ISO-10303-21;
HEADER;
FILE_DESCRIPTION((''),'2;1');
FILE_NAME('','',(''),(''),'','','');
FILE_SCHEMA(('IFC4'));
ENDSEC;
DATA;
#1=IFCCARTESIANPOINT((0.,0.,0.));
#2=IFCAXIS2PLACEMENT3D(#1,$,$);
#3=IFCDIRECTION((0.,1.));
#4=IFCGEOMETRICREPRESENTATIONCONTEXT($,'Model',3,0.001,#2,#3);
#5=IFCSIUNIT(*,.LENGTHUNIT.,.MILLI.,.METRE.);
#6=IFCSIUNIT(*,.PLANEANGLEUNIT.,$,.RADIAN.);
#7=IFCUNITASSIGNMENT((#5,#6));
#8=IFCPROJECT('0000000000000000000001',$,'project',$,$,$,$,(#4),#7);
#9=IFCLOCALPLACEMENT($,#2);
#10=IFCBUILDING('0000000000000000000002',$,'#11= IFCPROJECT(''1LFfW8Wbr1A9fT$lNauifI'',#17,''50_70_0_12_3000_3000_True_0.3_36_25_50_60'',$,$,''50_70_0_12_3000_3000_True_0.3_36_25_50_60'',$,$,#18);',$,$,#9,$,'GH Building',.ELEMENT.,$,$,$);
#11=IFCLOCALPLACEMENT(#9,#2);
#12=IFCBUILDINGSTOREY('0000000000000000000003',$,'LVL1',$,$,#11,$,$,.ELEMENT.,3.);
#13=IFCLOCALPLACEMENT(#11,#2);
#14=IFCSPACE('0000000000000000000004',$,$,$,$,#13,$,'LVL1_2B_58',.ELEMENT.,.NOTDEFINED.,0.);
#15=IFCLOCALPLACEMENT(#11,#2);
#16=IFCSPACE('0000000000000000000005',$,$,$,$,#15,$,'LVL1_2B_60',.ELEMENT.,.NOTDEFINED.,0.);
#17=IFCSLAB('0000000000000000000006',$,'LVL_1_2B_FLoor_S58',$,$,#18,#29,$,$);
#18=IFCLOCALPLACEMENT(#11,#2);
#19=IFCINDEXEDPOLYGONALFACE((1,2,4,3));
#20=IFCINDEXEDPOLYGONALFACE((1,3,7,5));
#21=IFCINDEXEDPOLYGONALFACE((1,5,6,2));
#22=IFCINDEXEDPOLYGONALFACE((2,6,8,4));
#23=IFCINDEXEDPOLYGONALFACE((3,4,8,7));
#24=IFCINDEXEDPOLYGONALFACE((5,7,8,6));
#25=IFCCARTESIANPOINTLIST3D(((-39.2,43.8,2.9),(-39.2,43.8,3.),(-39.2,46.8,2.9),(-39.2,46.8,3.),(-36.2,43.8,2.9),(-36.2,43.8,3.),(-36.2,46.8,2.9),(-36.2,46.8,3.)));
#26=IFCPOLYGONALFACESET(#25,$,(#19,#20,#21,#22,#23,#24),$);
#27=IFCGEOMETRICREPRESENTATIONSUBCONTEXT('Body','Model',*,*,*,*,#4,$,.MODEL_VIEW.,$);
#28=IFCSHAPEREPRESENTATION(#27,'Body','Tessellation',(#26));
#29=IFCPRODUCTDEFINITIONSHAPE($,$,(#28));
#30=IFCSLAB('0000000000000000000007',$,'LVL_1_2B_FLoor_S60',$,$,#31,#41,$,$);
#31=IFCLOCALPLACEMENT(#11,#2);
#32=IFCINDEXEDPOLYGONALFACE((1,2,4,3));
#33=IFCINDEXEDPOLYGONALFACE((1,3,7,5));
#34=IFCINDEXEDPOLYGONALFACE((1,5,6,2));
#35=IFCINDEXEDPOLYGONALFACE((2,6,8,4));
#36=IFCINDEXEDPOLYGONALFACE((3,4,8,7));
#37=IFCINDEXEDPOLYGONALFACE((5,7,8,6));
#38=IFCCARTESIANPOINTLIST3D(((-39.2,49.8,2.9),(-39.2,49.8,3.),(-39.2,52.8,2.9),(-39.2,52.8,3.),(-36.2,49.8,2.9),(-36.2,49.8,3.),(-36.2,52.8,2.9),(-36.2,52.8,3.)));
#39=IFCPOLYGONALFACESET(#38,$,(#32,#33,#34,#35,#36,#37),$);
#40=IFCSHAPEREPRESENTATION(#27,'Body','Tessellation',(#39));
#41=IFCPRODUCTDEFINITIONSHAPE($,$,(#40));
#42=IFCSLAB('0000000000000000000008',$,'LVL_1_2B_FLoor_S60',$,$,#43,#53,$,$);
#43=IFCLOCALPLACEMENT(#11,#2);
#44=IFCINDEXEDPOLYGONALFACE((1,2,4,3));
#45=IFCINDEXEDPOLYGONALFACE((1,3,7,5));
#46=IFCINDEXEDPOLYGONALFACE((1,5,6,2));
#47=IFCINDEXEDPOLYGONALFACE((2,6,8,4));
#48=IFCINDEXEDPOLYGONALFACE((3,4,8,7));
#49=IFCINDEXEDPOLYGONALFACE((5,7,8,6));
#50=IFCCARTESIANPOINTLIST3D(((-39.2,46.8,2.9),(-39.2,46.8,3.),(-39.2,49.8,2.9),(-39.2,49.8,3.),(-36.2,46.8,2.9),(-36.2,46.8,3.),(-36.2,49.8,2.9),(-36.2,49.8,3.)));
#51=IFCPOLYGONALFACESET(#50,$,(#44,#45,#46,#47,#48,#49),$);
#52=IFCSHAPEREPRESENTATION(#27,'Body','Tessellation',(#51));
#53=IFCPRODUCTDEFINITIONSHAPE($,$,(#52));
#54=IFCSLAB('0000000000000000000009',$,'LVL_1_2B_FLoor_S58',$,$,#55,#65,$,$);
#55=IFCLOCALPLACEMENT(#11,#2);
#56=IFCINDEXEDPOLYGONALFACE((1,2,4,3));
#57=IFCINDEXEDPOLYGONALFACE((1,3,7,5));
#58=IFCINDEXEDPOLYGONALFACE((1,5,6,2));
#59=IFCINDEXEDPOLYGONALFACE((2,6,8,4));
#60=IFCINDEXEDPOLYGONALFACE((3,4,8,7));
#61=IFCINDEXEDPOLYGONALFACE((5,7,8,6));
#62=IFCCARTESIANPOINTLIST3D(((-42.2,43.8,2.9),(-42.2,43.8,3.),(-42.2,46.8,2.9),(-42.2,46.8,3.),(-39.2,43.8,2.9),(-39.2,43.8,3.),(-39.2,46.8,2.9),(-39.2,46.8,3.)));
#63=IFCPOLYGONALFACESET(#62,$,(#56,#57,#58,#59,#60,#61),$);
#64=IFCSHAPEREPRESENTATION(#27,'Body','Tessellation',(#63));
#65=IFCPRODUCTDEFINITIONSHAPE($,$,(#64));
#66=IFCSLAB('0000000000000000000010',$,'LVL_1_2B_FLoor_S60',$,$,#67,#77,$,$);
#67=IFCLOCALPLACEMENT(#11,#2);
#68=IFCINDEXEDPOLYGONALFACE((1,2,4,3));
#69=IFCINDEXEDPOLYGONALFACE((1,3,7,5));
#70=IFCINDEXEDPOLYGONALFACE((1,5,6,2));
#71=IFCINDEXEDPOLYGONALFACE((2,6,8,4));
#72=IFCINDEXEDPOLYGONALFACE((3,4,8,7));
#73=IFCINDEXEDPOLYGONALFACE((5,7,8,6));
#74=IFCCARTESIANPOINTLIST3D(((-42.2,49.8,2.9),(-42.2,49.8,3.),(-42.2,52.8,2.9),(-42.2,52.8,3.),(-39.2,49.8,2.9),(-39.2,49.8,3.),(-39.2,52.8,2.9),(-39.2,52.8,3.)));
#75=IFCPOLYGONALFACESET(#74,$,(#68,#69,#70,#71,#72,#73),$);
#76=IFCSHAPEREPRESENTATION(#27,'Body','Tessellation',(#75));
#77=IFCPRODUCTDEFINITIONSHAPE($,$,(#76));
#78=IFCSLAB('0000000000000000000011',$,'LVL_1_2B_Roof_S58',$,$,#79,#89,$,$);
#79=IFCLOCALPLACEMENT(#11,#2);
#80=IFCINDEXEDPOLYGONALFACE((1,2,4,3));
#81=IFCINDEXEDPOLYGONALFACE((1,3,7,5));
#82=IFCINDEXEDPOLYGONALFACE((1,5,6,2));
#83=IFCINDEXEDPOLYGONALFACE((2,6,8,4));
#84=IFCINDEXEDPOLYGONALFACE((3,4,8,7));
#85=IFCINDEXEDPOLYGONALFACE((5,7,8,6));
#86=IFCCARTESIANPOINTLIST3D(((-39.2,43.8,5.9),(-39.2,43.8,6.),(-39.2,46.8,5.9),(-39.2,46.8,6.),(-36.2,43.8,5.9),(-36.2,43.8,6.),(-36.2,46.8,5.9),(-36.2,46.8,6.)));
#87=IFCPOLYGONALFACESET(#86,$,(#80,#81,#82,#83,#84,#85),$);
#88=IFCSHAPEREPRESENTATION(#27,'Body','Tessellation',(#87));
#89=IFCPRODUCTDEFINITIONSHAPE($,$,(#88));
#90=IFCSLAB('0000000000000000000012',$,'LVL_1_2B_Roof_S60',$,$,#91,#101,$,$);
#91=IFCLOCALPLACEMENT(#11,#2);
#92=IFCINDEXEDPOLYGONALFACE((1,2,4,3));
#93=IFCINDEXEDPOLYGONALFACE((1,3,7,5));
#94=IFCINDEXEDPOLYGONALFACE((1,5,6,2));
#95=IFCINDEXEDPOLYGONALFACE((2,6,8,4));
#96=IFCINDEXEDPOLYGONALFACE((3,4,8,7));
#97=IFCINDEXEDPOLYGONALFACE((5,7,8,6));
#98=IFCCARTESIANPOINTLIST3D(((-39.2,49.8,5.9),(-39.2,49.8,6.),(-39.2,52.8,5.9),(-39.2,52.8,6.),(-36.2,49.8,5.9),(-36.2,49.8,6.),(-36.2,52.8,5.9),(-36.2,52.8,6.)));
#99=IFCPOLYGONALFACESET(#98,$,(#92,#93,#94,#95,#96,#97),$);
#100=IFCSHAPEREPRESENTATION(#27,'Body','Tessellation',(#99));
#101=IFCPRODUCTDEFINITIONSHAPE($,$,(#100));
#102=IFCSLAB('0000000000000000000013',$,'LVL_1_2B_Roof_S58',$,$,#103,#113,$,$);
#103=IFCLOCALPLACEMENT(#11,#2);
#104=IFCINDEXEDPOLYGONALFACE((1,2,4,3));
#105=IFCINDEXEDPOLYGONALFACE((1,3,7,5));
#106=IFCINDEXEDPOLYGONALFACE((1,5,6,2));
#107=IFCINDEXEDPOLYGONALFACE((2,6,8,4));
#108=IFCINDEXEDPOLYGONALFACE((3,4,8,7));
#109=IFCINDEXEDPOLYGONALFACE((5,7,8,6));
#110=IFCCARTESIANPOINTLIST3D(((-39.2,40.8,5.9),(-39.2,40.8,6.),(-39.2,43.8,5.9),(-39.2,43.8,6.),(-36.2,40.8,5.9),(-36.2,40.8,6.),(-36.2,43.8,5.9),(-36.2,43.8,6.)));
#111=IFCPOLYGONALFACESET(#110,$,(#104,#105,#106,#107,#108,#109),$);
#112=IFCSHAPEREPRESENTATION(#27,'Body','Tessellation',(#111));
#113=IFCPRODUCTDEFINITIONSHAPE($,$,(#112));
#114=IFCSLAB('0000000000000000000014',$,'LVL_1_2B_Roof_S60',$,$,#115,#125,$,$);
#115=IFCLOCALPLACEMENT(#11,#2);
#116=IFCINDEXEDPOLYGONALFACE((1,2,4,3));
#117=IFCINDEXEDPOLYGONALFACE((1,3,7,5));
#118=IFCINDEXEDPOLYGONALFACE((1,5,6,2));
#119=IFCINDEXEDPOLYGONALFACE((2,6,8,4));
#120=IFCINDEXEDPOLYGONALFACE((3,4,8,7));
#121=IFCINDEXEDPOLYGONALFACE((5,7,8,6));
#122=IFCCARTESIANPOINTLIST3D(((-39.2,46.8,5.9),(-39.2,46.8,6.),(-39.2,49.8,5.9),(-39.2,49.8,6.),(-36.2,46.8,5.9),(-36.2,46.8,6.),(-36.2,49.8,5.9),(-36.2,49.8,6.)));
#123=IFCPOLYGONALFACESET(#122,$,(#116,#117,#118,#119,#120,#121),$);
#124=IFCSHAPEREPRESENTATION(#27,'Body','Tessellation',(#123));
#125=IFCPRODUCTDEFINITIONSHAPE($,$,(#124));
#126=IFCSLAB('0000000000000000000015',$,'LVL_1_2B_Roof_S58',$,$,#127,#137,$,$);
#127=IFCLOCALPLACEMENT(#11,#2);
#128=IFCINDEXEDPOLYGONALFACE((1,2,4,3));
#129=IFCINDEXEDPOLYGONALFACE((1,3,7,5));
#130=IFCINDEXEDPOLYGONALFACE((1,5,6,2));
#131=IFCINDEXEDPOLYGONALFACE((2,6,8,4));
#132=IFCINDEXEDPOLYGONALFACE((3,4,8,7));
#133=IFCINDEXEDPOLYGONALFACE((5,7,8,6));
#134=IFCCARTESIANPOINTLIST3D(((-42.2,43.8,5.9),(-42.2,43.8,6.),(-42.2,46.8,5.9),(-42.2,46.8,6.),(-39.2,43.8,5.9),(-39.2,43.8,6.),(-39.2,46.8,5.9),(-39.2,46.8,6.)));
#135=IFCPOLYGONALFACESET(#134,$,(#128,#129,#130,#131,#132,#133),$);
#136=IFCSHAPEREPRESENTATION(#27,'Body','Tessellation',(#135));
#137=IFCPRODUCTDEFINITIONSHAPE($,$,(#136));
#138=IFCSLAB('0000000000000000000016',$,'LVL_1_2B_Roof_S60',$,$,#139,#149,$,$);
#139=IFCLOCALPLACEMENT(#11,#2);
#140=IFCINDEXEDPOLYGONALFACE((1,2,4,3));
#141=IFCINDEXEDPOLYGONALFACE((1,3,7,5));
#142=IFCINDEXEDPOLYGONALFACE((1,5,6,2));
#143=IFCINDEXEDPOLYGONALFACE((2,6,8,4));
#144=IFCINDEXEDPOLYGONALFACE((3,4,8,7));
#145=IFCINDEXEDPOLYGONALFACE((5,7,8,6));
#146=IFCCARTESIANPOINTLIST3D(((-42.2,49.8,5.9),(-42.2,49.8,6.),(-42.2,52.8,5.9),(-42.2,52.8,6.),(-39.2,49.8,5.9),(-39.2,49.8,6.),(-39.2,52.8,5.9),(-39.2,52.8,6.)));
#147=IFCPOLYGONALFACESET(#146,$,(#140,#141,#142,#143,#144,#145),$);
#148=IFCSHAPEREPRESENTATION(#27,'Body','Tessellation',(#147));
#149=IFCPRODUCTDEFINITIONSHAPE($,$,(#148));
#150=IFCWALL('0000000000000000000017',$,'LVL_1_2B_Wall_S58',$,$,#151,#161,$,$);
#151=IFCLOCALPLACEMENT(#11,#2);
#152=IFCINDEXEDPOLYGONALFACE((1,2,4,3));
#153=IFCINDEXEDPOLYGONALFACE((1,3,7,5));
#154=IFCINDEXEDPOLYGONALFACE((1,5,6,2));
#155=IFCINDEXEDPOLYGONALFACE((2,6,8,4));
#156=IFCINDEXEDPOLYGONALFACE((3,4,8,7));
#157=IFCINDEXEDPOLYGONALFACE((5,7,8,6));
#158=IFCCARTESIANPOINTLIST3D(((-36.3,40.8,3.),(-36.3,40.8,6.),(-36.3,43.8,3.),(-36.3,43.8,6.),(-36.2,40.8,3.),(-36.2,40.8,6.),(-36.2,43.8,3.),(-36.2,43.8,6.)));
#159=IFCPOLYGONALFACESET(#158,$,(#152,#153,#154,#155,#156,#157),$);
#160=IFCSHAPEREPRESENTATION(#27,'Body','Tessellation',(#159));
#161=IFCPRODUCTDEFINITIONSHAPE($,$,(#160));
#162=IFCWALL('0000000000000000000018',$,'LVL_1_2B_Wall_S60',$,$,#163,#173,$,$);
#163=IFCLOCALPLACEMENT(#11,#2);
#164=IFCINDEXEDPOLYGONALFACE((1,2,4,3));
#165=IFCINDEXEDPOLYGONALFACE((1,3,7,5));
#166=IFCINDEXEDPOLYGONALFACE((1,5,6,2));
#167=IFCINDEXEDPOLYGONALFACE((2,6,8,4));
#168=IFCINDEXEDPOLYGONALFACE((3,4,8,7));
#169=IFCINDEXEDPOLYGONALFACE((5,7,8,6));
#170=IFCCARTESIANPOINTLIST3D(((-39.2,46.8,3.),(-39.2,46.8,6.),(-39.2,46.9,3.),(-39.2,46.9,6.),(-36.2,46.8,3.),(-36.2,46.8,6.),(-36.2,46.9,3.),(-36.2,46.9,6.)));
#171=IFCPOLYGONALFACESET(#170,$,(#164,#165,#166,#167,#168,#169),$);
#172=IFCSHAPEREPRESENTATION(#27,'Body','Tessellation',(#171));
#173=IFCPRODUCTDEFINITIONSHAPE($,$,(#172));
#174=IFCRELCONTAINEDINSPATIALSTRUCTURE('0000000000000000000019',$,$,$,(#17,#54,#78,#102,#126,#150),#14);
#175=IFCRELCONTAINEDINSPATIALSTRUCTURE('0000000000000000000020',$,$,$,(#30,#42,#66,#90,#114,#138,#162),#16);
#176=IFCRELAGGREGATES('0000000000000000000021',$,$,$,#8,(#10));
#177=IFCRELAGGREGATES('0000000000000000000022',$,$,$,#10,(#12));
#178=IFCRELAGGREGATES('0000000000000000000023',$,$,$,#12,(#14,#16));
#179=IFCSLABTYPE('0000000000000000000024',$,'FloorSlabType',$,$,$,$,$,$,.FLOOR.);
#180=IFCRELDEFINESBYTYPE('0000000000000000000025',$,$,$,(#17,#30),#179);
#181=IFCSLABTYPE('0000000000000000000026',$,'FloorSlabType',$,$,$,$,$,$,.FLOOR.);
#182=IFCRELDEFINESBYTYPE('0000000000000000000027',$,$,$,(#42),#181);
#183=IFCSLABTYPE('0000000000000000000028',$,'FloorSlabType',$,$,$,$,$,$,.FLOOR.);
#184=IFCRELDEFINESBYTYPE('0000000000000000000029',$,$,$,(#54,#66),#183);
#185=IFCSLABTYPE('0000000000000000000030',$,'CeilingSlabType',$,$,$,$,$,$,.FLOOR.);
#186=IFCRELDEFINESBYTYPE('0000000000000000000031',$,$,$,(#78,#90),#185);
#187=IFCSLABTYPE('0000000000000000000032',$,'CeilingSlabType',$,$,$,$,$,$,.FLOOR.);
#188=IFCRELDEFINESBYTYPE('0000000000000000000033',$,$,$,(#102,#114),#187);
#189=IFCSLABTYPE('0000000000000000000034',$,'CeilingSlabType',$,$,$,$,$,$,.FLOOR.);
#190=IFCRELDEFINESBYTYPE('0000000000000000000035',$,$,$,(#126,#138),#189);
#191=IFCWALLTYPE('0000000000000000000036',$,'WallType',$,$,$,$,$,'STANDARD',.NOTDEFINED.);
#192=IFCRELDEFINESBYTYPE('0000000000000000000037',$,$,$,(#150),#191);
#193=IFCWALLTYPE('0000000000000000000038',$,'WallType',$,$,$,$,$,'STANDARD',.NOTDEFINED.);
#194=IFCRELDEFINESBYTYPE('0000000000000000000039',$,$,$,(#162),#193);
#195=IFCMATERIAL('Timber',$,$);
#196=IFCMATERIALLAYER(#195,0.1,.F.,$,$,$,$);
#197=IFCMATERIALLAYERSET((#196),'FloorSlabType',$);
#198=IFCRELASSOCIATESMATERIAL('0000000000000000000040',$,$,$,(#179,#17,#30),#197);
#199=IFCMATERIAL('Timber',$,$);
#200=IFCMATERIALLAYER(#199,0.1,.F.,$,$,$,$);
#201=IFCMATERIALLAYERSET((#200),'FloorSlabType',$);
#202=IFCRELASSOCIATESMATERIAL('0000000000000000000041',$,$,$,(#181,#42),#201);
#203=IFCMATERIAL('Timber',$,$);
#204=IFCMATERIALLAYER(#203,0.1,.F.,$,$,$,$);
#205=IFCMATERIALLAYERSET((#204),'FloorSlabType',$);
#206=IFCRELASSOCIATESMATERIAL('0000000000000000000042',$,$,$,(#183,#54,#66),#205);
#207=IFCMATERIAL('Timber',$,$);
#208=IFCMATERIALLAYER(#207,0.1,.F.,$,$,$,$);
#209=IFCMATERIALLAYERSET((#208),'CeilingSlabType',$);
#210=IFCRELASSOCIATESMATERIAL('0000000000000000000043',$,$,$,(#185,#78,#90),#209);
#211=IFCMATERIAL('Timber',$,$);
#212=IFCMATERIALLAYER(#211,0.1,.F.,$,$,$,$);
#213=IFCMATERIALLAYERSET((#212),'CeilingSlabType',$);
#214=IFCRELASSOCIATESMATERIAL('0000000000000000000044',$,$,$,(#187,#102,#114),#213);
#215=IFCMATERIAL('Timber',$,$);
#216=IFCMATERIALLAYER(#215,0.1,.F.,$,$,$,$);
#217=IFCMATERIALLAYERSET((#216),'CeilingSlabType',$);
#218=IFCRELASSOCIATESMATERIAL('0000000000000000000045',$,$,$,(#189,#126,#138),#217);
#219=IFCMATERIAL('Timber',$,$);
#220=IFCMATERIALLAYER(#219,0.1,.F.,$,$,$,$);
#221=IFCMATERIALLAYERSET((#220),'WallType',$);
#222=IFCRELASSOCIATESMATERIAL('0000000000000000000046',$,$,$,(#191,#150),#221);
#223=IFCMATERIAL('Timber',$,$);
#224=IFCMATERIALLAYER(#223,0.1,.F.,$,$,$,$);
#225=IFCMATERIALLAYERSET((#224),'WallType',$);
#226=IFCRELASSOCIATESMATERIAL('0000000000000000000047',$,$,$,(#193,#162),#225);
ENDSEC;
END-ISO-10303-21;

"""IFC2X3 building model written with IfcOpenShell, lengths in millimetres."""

from ifc_helpers import new_model, si_unit, direction, frame, frame_2d, origin, place, context, subcontext, project, spatial, rectangle, extrude, material, layer, layer_set, layer_usage, type_object, element, save


model = new_model("IFC2X3")

# Units and contexts
model_context = context("Model", 3, precision=0.001, world=origin(), true_north=direction((0.0, 1.0)))
body_context = subcontext(model_context, "Body", "Model", "MODEL_VIEW")
ifc_project = project(units=[si_unit("LENGTHUNIT", "METRE", prefix="MILLI"), si_unit("PLANEANGLEUNIT", "RADIAN")], contexts=[model_context])

# Building, storey
building_placement = place(None, origin())
building = spatial("IfcBuilding", under=ifc_project, at=building_placement, Name="#11= IFCPROJECT('1LFfW8Wbr1A9fT$lNauifI',#17,'50_70_0_12_3000_3000_True_0.3_36_25_50_60',$,$,'50_70_0_12_3000_3000_True_0.3_36_25_50_60',$,$,#18);", LongName="GH Building", CompositionType="ELEMENT")
storey_placement = place(building_placement, origin())
storey = spatial("IfcBuildingStorey", under=building, at=storey_placement, Name="LVL1", CompositionType="ELEMENT", Elevation=3.0)

# Shared definitions
space_1_placement = place(storey_placement, origin())
space_1 = spatial("IfcSpace", under=storey, at=space_1_placement, LongName="LVL1_2B_58", CompositionType="ELEMENT", InteriorOrExteriorSpace="NOTDEFINED", ElevationWithFlooring=0.0)

# Slab
ifc_material_1 = material(Name="Timber")
ifc_layer_1 = layer(ifc_material_1, 0.1, ventilated=False)
ifc_layer_set_1 = layer_set([ifc_layer_1], Name="FloorSlabType")
ifc_layer_usage_1 = layer_usage(ifc_layer_set_1, "AXIS3", "NEGATIVE", -0.1)
slab_type_1 = type_object("IfcSlabType", Name="FloorSlabType", PredefinedType="FLOOR", material=ifc_layer_set_1)
slab_1_placement = place(space_1_placement, frame((-39.2, 46.8, 2.9), z_axis=(0.0, 0.0, 1.0), x_axis=(0.0, -1.0, 0.0)))
element("IfcSlab", 1, at=slab_1_placement, inside=space_1, type_object=slab_type_1, material=ifc_layer_usage_1, Name="LVL_1_2B_FLoor_S58", context=body_context, shape_type="SweptSolid", body=[
    extrude(rectangle(XDim=3.0, YDim=3.0, at=frame_2d((1.5, 1.5))), origin(), (0.0, 0.0, 1.0), 0.1),
])

# Shared definitions
space_2_placement = place(storey_placement, origin())
space_2 = spatial("IfcSpace", under=storey, at=space_2_placement, LongName="LVL1_2B_60", CompositionType="ELEMENT", InteriorOrExteriorSpace="NOTDEFINED", ElevationWithFlooring=0.0)

# Slabs
ifc_layer_usage_2 = layer_usage(ifc_layer_set_1, "AXIS3", "NEGATIVE", -0.1)
slab_2_placement = place(space_2_placement, frame((-39.2, 52.8, 2.9), z_axis=(0.0, 0.0, 1.0), x_axis=(0.0, -1.0, 0.0)))
element("IfcSlab", 2, at=slab_2_placement, inside=space_2, type_object=slab_type_1, material=ifc_layer_usage_2, Name="LVL_1_2B_FLoor_S60", context=body_context, shape_type="SweptSolid", body=[
    extrude(rectangle(XDim=3.0, YDim=3.0, at=frame_2d((1.5, 1.5))), origin(), (0.0, 0.0, 1.0), 0.1),
])
ifc_material_2 = material(Name="Timber")
ifc_layer_2 = layer(ifc_material_2, 0.1, ventilated=False)
ifc_layer_set_2 = layer_set([ifc_layer_2], Name="FloorSlabType")
ifc_layer_usage_3 = layer_usage(ifc_layer_set_2, "AXIS3", "NEGATIVE", -0.1)
slab_type_2 = type_object("IfcSlabType", Name="FloorSlabType", PredefinedType="FLOOR", material=ifc_layer_set_2)
slab_3_placement = place(space_2_placement, frame((-39.2, 49.8, 2.9), z_axis=(0.0, 0.0, 1.0), x_axis=(0.0, -1.0, 0.0)))
element("IfcSlab", 3, at=slab_3_placement, inside=space_2, type_object=slab_type_2, material=ifc_layer_usage_3, Name="LVL_1_2B_FLoor_S60", context=body_context, shape_type="SweptSolid", body=[
    extrude(rectangle(XDim=3.0, YDim=3.0, at=frame_2d((1.5, 1.5))), origin(), (0.0, 0.0, 1.0), 0.1),
])
ifc_material_3 = material(Name="Timber")
ifc_layer_3 = layer(ifc_material_3, 0.1, ventilated=False)
ifc_layer_set_3 = layer_set([ifc_layer_3], Name="FloorSlabType")
ifc_layer_usage_4 = layer_usage(ifc_layer_set_3, "AXIS3", "NEGATIVE", -0.1)
slab_type_3 = type_object("IfcSlabType", Name="FloorSlabType", PredefinedType="FLOOR", material=ifc_layer_set_3)
slab_4_placement = place(space_1_placement, frame((-42.2, 46.8, 2.9), z_axis=(0.0, 0.0, 1.0), x_axis=(0.0, -1.0, 0.0)))
element("IfcSlab", 4, at=slab_4_placement, inside=space_1, type_object=slab_type_3, material=ifc_layer_usage_4, Name="LVL_1_2B_FLoor_S58", context=body_context, shape_type="SweptSolid", body=[
    extrude(rectangle(XDim=3.0, YDim=3.0, at=frame_2d((1.5, 1.5))), origin(), (0.0, 0.0, 1.0), 0.1),
])
ifc_layer_usage_5 = layer_usage(ifc_layer_set_3, "AXIS3", "NEGATIVE", -0.1)
slab_5_placement = place(space_2_placement, frame((-42.2, 52.8, 2.9), z_axis=(0.0, 0.0, 1.0), x_axis=(0.0, -1.0, 0.0)))
element("IfcSlab", 5, at=slab_5_placement, inside=space_2, type_object=slab_type_3, material=ifc_layer_usage_5, Name="LVL_1_2B_FLoor_S60", context=body_context, shape_type="SweptSolid", body=[
    extrude(rectangle(XDim=3.0, YDim=3.0, at=frame_2d((1.5, 1.5))), origin(), (0.0, 0.0, 1.0), 0.1),
])
ifc_material_4 = material(Name="Timber")
ifc_layer_4 = layer(ifc_material_4, 0.1, ventilated=False)
ifc_layer_set_4 = layer_set([ifc_layer_4], Name="CeilingSlabType")
ifc_layer_usage_6 = layer_usage(ifc_layer_set_4, "AXIS3", "NEGATIVE", -0.1)
slab_type_4 = type_object("IfcSlabType", Name="CeilingSlabType", PredefinedType="FLOOR", material=ifc_layer_set_4)
slab_6_placement = place(space_1_placement, frame((-39.2, 46.8, 5.9), z_axis=(0.0, 0.0, 1.0), x_axis=(0.0, -1.0, 0.0)))
element("IfcSlab", 6, at=slab_6_placement, inside=space_1, type_object=slab_type_4, material=ifc_layer_usage_6, Name="LVL_1_2B_Roof_S58", context=body_context, shape_type="SweptSolid", body=[
    extrude(rectangle(XDim=3.0, YDim=3.0, at=frame_2d((1.5, 1.5))), origin(), (0.0, 0.0, 1.0), 0.1),
])
ifc_layer_usage_7 = layer_usage(ifc_layer_set_4, "AXIS3", "NEGATIVE", -0.1)
slab_7_placement = place(space_2_placement, frame((-39.2, 52.8, 5.9), z_axis=(0.0, 0.0, 1.0), x_axis=(0.0, -1.0, 0.0)))
element("IfcSlab", 7, at=slab_7_placement, inside=space_2, type_object=slab_type_4, material=ifc_layer_usage_7, Name="LVL_1_2B_Roof_S60", context=body_context, shape_type="SweptSolid", body=[
    extrude(rectangle(XDim=3.0, YDim=3.0, at=frame_2d((1.5, 1.5))), origin(), (0.0, 0.0, 1.0), 0.1),
])
ifc_material_5 = material(Name="Timber")
ifc_layer_5 = layer(ifc_material_5, 0.1, ventilated=False)
ifc_layer_set_5 = layer_set([ifc_layer_5], Name="CeilingSlabType")
ifc_layer_usage_8 = layer_usage(ifc_layer_set_5, "AXIS3", "NEGATIVE", -0.1)
slab_type_5 = type_object("IfcSlabType", Name="CeilingSlabType", PredefinedType="FLOOR", material=ifc_layer_set_5)
slab_8_placement = place(space_1_placement, frame((-39.2, 43.8, 5.9), z_axis=(0.0, 0.0, 1.0), x_axis=(0.0, -1.0, 0.0)))
element("IfcSlab", 8, at=slab_8_placement, inside=space_1, type_object=slab_type_5, material=ifc_layer_usage_8, Name="LVL_1_2B_Roof_S58", context=body_context, shape_type="SweptSolid", body=[
    extrude(rectangle(XDim=3.0, YDim=3.0, at=frame_2d((1.5, 1.5))), origin(), (0.0, 0.0, 1.0), 0.1),
])
ifc_layer_usage_9 = layer_usage(ifc_layer_set_5, "AXIS3", "NEGATIVE", -0.1)
slab_9_placement = place(space_2_placement, frame((-39.2, 49.8, 5.9), z_axis=(0.0, 0.0, 1.0), x_axis=(0.0, -1.0, 0.0)))
element("IfcSlab", 9, at=slab_9_placement, inside=space_2, type_object=slab_type_5, material=ifc_layer_usage_9, Name="LVL_1_2B_Roof_S60", context=body_context, shape_type="SweptSolid", body=[
    extrude(rectangle(XDim=3.0, YDim=3.0, at=frame_2d((1.5, 1.5))), origin(), (0.0, 0.0, 1.0), 0.1),
])
ifc_material_6 = material(Name="Timber")
ifc_layer_6 = layer(ifc_material_6, 0.1, ventilated=False)
ifc_layer_set_6 = layer_set([ifc_layer_6], Name="CeilingSlabType")
ifc_layer_usage_10 = layer_usage(ifc_layer_set_6, "AXIS3", "NEGATIVE", -0.1)
slab_type_6 = type_object("IfcSlabType", Name="CeilingSlabType", PredefinedType="FLOOR", material=ifc_layer_set_6)
slab_10_placement = place(space_1_placement, frame((-42.2, 46.8, 5.9), z_axis=(0.0, 0.0, 1.0), x_axis=(0.0, -1.0, 0.0)))
element("IfcSlab", 10, at=slab_10_placement, inside=space_1, type_object=slab_type_6, material=ifc_layer_usage_10, Name="LVL_1_2B_Roof_S58", context=body_context, shape_type="SweptSolid", body=[
    extrude(rectangle(XDim=3.0, YDim=3.0, at=frame_2d((1.5, 1.5))), origin(), (0.0, 0.0, 1.0), 0.1),
])
ifc_layer_usage_11 = layer_usage(ifc_layer_set_6, "AXIS3", "NEGATIVE", -0.1)
slab_11_placement = place(space_2_placement, frame((-42.2, 52.8, 5.9), z_axis=(0.0, 0.0, 1.0), x_axis=(0.0, -1.0, 0.0)))
element("IfcSlab", 11, at=slab_11_placement, inside=space_2, type_object=slab_type_6, material=ifc_layer_usage_11, Name="LVL_1_2B_Roof_S60", context=body_context, shape_type="SweptSolid", body=[
    extrude(rectangle(XDim=3.0, YDim=3.0, at=frame_2d((1.5, 1.5))), origin(), (0.0, 0.0, 1.0), 0.1),
])

# Walls
ifc_material_7 = material(Name="Timber")
ifc_layer_7 = layer(ifc_material_7, 0.1, ventilated=False)
ifc_layer_set_7 = layer_set([ifc_layer_7], Name="WallType")
ifc_layer_usage_12 = layer_usage(ifc_layer_set_7, "AXIS2", "NEGATIVE", 0.0)
wall_type_1 = type_object("IfcWallType", Name="WallType", ElementType="STANDARD", PredefinedType="NOTDEFINED", material=ifc_layer_set_7)
wall_1_placement = place(space_1_placement, frame((-36.2, 43.8, 3.0), z_axis=(0.0, 0.0, 1.0), x_axis=(0.0, -1.0, 0.0)))
element("IfcWall", 12, at=wall_1_placement, inside=space_1, type_object=wall_type_1, material=ifc_layer_usage_12, Name="LVL_1_2B_Wall_S58", context=body_context, shape_type="SweptSolid", body=[
    extrude(rectangle(XDim=3.0, YDim=0.1, at=frame_2d((1.5, -0.1))), origin(), (0.0, 0.0, 1.0), 3.0),
])
ifc_material_8 = material(Name="Timber")
ifc_layer_8 = layer(ifc_material_8, 0.1, ventilated=False)
ifc_layer_set_8 = layer_set([ifc_layer_8], Name="WallType")
ifc_layer_usage_13 = layer_usage(ifc_layer_set_8, "AXIS2", "NEGATIVE", 0.0)
wall_type_2 = type_object("IfcWallType", Name="WallType", ElementType="STANDARD", PredefinedType="NOTDEFINED", material=ifc_layer_set_8)
wall_2_placement = place(space_2_placement, frame((-36.2, 46.8, 3.0), z_axis=(0.0, 0.0, 1.0), x_axis=(-1.0, 0.0, 0.0)))
element("IfcWall", 13, at=wall_2_placement, inside=space_2, type_object=wall_type_2, material=ifc_layer_usage_13, Name="LVL_1_2B_Wall_S60", context=body_context, shape_type="SweptSolid", body=[
    extrude(rectangle(XDim=3.0, YDim=0.1, at=frame_2d((1.5, -0.1))), origin(), (0.0, 0.0, 1.0), 3.0),
])

save(model, "model.ifc")
